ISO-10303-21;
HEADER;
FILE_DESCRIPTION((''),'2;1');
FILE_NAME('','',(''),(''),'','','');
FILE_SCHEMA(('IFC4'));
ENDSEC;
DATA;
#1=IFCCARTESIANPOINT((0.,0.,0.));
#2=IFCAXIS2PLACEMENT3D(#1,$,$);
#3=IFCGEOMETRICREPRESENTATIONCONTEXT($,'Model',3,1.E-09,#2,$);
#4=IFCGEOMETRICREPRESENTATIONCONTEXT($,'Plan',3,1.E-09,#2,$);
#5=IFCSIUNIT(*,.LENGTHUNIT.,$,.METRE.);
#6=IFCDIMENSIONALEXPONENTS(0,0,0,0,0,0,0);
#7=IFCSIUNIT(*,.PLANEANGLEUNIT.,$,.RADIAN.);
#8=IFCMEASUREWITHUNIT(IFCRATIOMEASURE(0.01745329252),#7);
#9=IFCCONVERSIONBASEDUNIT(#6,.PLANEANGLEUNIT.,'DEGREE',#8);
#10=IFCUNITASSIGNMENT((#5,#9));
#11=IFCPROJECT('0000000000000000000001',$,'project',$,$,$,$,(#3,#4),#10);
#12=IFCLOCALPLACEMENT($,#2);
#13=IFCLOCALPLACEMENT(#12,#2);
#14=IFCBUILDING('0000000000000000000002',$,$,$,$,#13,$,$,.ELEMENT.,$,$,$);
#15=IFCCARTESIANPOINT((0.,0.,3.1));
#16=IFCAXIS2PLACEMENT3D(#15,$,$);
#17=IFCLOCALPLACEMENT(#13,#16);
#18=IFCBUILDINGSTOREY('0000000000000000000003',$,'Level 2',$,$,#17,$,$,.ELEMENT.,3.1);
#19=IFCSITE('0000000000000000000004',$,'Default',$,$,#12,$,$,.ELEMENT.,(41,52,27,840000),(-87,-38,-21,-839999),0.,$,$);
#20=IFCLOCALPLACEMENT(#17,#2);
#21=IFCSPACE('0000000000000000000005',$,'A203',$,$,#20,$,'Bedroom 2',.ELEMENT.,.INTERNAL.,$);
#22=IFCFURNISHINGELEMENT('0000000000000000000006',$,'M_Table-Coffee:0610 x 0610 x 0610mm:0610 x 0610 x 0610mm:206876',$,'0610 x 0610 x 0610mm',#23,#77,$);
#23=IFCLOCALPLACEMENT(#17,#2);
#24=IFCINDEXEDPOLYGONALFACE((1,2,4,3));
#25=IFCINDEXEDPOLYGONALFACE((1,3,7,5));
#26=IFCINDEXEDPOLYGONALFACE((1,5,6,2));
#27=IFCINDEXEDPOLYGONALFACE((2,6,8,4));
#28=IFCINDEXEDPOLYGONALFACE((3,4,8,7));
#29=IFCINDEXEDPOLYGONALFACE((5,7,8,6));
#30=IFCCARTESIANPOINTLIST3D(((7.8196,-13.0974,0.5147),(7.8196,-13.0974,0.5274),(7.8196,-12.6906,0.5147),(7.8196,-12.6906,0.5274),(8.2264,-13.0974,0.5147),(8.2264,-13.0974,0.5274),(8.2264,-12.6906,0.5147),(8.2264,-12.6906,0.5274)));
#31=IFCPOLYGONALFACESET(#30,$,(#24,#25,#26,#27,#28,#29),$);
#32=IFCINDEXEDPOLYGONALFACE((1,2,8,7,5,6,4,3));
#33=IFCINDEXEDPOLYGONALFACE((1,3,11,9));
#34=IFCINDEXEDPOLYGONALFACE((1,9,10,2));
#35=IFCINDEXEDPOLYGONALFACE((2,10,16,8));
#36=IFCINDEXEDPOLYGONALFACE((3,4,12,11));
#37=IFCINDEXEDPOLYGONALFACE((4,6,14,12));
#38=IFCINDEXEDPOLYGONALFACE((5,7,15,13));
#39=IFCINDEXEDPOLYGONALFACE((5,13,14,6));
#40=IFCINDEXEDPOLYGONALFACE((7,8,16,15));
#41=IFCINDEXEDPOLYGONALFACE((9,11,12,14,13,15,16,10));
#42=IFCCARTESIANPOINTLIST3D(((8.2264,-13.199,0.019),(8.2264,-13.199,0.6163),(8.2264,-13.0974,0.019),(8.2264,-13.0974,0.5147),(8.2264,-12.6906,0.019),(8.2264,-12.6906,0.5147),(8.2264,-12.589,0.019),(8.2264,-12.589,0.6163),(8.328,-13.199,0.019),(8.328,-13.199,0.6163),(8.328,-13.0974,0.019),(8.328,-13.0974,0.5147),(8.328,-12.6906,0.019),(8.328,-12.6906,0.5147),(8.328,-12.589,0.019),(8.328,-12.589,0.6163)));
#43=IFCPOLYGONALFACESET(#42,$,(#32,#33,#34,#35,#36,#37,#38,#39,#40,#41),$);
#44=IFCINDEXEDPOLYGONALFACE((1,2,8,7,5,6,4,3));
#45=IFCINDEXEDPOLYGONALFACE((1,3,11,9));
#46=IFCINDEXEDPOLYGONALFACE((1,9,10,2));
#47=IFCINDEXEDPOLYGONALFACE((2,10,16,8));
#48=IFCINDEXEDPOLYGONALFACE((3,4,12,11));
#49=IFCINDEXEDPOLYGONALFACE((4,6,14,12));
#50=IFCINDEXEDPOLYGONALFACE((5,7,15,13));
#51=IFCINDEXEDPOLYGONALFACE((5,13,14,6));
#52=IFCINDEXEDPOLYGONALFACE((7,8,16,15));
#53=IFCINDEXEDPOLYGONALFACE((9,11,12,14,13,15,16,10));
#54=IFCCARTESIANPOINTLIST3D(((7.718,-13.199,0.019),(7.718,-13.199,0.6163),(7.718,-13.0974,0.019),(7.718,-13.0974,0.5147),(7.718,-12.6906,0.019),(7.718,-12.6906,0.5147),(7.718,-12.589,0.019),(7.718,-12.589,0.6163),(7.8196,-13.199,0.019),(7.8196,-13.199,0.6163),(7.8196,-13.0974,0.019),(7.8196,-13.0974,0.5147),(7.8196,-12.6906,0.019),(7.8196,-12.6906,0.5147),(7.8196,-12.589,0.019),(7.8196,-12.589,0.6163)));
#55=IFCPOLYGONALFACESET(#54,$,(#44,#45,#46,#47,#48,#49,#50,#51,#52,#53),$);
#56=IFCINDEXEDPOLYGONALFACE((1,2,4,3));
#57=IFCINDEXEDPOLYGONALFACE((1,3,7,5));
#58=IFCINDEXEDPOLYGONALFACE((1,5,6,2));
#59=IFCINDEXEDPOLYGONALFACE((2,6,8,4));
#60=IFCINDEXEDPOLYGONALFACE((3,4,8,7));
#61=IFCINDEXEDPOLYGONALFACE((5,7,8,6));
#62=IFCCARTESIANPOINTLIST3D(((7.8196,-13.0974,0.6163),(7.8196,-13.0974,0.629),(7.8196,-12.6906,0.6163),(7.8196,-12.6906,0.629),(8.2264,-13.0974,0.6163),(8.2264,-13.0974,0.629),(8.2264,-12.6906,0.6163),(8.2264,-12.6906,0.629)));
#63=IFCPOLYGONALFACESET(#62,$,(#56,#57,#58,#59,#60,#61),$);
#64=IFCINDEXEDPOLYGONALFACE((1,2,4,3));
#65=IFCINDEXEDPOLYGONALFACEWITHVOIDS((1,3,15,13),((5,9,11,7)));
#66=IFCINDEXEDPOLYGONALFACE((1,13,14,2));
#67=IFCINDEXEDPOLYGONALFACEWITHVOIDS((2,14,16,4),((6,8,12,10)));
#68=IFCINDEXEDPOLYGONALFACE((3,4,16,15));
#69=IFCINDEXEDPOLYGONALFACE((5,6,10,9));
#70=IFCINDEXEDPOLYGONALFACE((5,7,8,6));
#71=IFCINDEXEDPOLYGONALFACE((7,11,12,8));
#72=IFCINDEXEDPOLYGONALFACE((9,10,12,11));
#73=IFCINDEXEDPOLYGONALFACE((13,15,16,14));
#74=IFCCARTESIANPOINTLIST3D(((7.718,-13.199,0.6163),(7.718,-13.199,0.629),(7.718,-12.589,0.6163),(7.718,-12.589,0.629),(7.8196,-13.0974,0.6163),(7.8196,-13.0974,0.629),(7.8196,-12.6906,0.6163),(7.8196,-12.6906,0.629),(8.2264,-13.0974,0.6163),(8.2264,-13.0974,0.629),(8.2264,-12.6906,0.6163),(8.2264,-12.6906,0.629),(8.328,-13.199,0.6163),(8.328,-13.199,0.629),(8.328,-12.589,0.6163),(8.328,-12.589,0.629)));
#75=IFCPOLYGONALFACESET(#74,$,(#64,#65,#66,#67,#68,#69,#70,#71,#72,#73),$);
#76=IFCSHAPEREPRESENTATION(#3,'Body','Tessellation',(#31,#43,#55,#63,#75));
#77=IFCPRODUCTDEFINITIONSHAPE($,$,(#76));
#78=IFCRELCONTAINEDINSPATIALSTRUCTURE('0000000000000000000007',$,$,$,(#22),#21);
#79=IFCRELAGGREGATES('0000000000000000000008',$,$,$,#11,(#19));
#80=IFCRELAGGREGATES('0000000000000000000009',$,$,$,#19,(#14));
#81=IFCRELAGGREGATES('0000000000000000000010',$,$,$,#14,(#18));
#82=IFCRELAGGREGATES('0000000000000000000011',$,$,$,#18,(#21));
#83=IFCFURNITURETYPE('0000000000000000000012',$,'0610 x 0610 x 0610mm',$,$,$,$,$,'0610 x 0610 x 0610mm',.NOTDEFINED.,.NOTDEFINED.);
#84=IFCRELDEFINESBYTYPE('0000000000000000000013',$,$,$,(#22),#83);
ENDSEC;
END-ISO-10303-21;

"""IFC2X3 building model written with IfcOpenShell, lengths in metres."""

from ifc_helpers import new_model, entity, si_unit, converted_unit, frame, origin, origin_2d_with_axis, place, context, project, spatial, polyline, rectangle, outline, extrude, source, transform, mapped, type_object, type_shapes, element, save


model = new_model("IFC2X3")

# Units and contexts
model_context = context("Model", 3, precision=1e-09, world=origin())
plan_context = context("Plan", 3, precision=1e-09, world=origin())
ifc_project = project(units=[si_unit("LENGTHUNIT", "METRE"), converted_unit("PLANEANGLEUNIT", "DEGREE", entity("IfcRatioMeasure", 0.01745329252), si_unit("PLANEANGLEUNIT", "RADIAN"), dimensions=[0, 0, 0, 0, 0, 0, 0])], contexts=[model_context, plan_context])

# Site, building, storey
site_placement = place(None, origin())
site = spatial("IfcSite", under=ifc_project, at=site_placement, Name="Default", CompositionType="ELEMENT", RefLatitude=(41, 52, 27, 840000), RefLongitude=(-87, -38, -21, -839999), RefElevation=0.0)
building_placement = place(site_placement, origin())
building = spatial("IfcBuilding", under=site, at=building_placement, CompositionType="ELEMENT")
storey_placement = place(building_placement, frame((0.0, 0.0, 3.1)))
storey = spatial("IfcBuildingStorey", under=building, at=storey_placement, Name="Level 2", CompositionType="ELEMENT", Elevation=3.1)

# Shared definitions
space_placement = place(storey_placement, origin())
space = spatial("IfcSpace", under=storey, at=space_placement, Name="A203", LongName="Bedroom 2", CompositionType="ELEMENT", InteriorOrExteriorSpace="INTERNAL")

# Furnishing element
furniture_type = type_object("IfcFurnitureType", Name="0610 x 0610 x 0610mm", ElementType="0610 x 0610 x 0610mm", AssemblyPlace="NOTDEFINED")
shared_shape_1 = source(origin(), model_context, "Body", "SweptSolid", [
    extrude(rectangle(XDim=0.4068, YDim=0.4068, at=origin_2d_with_axis()), frame((0.0183, 0.0952, 0.4957), z_axis=(0.0, 0.0, 1.0), x_axis=(-1.0, 0.0, 0.0)), (0.0, 0.0, 1.0), 0.0127),
    extrude(outline(polyline([(-0.2732, -0.305), (0.3241, -0.305), (0.3241, 0.305), (-0.2732, 0.305), (-0.2732, 0.2034), (0.2225, 0.2034), (0.2225, -0.2034), (-0.2732, -0.2034), (-0.2732, -0.305)])), frame((0.2217, 0.0952, 0.2732), z_axis=(1.0, 0.0, 0.0), x_axis=(0.0, 0.0, 1.0)), (0.0, 0.0, 1.0), 0.1016),
    extrude(outline(polyline([(-0.305, -0.3241), (0.305, -0.3241), (0.305, 0.2732), (0.2034, 0.2732), (0.2034, -0.2225), (-0.2034, -0.2225), (-0.2034, 0.2732), (-0.305, 0.2732), (-0.305, -0.3241)])), frame((-0.2867, 0.0952, 0.2732), z_axis=(1.0, 0.0, 0.0), x_axis=(0.0, -1.0, 0.0)), (0.0, 0.0, 1.0), 0.1016),
    extrude(rectangle(XDim=0.4068, YDim=0.4068, at=origin_2d_with_axis()), frame((0.0183, 0.0952, 0.5973), z_axis=(0.0, 0.0, 1.0), x_axis=(-1.0, 0.0, 0.0)), (0.0, 0.0, 1.0), 0.0127),
    extrude(outline(polyline([(-0.305, -0.305), (0.305, -0.305), (0.305, 0.305), (-0.305, 0.305), (-0.305, -0.305)]), holes=[polyline([(-0.2034, -0.2034), (-0.2034, 0.2034), (0.2034, 0.2034), (0.2034, -0.2034), (-0.2034, -0.2034)])]), frame((0.0183, 0.0952, 0.5973), z_axis=(0.0, 0.0, 1.0), x_axis=(-1.0, 0.0, 0.0)), (0.0, 0.0, 1.0), 0.0127),
])
type_shapes(furniture_type, [shared_shape_1])
furnishing_placement = place(space_placement, frame((8.0047, -12.9892, 0.019)))
element("IfcFurnishingElement", 1, at=furnishing_placement, inside=space, type_object=furniture_type, Name="M_Table-Coffee:0610 x 0610 x 0610mm:0610 x 0610 x 0610mm:206876", ObjectType="0610 x 0610 x 0610mm", context=model_context, shape_type="MappedRepresentation", body=[
    mapped(shared_shape_1, transform((0.0, 0.0, 0.0), scale=1.0)),
])

save(model, "model.ifc")
